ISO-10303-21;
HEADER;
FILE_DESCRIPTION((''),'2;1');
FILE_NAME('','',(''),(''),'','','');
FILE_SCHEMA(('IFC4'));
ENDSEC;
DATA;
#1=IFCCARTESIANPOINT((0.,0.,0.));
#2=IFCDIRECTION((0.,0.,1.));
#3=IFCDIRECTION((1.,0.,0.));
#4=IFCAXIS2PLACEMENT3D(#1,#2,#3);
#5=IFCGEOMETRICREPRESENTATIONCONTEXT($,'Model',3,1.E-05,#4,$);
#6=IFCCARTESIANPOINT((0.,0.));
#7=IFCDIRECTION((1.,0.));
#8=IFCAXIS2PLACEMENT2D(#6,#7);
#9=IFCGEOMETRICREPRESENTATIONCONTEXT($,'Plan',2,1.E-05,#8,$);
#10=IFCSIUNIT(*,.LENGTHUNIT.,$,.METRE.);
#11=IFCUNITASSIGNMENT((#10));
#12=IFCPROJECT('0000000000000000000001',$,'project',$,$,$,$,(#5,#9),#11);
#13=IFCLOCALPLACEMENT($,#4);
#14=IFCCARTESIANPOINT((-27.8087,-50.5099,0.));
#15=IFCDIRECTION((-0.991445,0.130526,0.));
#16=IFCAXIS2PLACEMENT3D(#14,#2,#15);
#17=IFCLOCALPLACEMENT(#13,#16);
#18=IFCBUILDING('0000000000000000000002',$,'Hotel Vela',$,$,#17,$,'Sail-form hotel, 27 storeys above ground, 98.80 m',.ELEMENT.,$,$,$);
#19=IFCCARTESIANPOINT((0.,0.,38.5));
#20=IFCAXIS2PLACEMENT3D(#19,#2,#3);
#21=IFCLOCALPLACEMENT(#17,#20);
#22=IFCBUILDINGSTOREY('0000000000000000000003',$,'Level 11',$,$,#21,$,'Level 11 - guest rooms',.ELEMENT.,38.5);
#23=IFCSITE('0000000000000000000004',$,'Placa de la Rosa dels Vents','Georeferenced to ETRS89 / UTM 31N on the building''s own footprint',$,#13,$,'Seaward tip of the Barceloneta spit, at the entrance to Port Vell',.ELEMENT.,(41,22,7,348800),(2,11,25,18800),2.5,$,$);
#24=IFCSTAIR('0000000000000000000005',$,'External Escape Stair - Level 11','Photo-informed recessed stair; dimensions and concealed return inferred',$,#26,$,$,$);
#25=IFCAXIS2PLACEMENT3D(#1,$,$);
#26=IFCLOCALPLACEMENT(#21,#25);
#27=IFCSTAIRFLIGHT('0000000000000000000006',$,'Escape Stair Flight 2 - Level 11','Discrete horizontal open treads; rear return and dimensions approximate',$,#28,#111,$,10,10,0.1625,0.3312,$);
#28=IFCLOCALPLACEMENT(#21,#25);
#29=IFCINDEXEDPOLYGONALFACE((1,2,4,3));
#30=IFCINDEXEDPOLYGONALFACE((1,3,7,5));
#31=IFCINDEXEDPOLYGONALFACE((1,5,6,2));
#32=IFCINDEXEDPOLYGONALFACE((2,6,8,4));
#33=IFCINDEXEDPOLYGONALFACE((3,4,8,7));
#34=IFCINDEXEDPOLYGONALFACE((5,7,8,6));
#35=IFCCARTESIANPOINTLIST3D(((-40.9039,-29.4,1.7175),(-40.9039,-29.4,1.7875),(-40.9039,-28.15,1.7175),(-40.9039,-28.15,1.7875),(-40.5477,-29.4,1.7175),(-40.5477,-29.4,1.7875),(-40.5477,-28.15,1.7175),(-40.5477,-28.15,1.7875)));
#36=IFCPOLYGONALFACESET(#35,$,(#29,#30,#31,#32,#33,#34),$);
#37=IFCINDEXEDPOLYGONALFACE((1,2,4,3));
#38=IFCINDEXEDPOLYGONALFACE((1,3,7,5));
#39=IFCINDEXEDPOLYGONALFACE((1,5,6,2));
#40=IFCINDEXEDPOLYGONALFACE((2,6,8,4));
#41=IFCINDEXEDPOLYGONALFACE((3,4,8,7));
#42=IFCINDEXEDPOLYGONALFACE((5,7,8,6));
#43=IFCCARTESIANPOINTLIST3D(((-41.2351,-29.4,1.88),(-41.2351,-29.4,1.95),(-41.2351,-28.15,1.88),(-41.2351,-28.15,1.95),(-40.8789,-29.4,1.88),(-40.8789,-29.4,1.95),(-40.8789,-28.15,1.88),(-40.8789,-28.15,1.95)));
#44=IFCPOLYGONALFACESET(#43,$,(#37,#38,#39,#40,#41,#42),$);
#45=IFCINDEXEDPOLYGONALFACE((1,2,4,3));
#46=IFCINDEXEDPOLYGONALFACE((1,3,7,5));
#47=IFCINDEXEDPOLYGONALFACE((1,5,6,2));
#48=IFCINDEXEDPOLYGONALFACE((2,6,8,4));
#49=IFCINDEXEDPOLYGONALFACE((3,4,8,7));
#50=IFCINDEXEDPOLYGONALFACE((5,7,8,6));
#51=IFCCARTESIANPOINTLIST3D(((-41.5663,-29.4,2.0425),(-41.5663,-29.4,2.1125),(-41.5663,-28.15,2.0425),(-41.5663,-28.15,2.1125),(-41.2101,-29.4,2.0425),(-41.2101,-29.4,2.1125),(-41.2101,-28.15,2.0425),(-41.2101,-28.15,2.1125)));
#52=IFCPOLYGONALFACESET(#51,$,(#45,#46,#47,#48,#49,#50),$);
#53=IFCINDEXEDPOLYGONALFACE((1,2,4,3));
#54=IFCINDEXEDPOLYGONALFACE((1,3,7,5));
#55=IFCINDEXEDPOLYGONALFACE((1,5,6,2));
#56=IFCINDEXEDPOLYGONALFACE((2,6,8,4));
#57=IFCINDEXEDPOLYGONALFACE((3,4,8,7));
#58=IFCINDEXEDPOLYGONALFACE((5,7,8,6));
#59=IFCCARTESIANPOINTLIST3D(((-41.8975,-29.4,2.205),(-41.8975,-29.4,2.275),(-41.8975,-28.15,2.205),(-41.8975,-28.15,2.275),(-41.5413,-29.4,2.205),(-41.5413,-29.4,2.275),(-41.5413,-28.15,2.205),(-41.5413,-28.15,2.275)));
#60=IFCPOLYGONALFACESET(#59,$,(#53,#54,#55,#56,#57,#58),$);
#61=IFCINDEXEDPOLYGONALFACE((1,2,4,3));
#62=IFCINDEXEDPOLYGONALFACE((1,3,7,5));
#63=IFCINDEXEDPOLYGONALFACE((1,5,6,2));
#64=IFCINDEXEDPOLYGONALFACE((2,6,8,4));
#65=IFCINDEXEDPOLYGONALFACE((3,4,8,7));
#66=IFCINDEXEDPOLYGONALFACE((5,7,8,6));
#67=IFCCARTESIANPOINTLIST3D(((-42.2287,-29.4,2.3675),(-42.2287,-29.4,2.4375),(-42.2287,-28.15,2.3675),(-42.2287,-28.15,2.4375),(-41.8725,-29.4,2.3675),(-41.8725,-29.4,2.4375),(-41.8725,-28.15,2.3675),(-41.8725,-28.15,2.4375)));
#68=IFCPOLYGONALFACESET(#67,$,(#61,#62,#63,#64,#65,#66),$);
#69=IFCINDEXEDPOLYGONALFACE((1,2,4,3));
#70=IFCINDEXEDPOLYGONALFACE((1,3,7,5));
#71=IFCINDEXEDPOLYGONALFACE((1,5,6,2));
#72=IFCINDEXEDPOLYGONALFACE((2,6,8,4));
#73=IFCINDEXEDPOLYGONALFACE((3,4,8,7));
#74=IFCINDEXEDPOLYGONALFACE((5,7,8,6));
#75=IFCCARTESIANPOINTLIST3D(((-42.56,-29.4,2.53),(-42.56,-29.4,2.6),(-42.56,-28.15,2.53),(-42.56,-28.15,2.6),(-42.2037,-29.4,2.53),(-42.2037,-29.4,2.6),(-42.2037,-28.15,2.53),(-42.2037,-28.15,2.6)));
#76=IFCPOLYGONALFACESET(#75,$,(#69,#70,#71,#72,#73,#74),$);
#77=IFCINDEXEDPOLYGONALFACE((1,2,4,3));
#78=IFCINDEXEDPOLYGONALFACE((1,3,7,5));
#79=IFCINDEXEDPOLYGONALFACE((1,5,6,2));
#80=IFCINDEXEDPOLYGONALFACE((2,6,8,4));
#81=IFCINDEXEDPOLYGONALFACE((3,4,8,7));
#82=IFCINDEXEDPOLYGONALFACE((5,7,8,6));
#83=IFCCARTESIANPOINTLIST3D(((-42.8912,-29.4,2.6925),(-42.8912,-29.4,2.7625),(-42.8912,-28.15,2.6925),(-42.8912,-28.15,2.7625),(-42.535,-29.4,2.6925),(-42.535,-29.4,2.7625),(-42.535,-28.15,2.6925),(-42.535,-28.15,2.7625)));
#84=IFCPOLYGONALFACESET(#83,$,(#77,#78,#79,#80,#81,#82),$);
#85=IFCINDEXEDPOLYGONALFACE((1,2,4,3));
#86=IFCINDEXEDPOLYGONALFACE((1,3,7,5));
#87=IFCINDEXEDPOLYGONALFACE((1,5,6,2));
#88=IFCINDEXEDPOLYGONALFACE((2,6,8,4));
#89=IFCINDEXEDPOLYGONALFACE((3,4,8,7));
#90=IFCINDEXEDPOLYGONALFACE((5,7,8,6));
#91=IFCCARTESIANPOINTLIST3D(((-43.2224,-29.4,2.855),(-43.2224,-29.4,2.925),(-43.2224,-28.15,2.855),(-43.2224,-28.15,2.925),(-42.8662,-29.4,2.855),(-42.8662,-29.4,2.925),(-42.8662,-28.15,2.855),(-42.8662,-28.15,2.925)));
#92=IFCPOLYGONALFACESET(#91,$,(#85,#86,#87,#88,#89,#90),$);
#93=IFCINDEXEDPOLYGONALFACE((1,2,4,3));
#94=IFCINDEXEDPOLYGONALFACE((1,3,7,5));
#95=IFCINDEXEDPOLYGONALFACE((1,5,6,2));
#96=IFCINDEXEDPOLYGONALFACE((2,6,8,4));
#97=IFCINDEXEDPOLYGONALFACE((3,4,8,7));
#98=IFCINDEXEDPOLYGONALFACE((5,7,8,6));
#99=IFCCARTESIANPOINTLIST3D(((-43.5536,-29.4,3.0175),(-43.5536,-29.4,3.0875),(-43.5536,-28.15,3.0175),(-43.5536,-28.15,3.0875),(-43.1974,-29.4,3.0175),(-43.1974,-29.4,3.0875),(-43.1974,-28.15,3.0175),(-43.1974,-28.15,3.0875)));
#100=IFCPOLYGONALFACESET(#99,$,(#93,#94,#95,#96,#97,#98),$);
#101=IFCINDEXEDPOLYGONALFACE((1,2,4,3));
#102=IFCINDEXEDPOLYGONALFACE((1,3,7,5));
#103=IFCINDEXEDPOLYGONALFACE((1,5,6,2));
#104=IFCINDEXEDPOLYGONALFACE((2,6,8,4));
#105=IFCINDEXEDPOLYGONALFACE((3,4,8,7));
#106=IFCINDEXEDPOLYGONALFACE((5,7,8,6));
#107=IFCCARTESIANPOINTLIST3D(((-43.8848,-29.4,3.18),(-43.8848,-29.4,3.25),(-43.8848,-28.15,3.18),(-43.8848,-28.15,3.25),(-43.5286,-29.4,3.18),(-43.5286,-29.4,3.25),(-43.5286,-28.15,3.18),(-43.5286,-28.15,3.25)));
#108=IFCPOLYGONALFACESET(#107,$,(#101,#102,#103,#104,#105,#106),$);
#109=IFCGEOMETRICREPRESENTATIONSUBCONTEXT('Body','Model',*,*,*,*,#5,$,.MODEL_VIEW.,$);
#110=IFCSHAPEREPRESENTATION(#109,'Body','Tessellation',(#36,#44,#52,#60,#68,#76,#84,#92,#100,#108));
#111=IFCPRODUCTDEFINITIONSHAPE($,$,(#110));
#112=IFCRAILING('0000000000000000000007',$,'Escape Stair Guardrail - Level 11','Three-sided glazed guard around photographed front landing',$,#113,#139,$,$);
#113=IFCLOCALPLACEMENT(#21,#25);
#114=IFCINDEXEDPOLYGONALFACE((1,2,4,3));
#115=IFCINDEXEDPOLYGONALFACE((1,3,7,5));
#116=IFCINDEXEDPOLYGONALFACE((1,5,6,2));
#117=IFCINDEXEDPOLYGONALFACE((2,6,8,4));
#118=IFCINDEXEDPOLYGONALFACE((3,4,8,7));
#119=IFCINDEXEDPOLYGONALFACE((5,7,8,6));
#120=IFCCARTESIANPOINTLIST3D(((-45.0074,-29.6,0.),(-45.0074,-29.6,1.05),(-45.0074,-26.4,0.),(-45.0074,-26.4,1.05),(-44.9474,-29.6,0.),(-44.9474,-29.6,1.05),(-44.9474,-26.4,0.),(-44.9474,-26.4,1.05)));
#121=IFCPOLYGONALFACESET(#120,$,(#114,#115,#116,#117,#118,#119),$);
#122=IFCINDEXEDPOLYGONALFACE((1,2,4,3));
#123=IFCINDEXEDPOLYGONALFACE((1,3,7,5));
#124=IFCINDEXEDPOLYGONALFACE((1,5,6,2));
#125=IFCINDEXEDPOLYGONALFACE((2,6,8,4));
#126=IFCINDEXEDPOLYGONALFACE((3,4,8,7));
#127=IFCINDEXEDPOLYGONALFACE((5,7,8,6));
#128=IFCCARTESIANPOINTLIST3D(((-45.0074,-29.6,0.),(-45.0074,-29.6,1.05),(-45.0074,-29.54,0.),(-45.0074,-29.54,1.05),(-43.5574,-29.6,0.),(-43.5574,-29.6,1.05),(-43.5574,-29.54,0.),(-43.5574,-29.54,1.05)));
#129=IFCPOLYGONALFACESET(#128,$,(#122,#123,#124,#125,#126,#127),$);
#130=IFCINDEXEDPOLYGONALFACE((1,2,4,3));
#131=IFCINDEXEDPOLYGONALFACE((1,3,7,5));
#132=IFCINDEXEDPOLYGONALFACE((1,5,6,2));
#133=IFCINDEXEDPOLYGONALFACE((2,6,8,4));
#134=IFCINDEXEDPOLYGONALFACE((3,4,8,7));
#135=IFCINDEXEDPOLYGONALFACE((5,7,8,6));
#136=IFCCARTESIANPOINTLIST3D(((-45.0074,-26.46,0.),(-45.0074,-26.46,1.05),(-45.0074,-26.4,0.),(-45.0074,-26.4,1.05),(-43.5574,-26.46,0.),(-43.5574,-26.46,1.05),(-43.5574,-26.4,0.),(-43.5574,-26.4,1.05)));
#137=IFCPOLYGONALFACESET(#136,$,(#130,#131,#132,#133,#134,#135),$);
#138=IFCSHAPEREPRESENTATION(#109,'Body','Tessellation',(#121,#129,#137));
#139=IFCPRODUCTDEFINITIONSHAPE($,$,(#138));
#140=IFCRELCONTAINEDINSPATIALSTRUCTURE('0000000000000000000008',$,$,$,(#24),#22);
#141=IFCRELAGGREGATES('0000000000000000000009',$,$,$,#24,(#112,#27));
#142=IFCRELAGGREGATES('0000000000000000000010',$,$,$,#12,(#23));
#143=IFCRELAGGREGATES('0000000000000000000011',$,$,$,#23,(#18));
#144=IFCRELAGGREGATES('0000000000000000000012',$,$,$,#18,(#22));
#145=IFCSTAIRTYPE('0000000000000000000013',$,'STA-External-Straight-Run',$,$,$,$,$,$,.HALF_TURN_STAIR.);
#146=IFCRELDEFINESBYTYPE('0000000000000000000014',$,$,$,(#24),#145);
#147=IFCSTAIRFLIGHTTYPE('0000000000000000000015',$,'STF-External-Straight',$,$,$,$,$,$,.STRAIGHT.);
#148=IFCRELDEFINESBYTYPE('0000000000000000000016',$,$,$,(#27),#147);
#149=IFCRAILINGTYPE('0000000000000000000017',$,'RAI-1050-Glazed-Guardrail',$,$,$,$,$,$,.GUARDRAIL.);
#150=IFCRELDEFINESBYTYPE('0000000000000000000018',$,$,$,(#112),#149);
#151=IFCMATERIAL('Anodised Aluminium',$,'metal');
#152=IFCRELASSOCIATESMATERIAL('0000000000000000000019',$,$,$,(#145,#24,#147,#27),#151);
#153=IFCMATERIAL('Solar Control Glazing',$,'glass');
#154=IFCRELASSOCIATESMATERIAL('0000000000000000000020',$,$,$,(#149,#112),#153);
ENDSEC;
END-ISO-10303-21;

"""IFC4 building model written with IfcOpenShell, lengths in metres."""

from ifc_helpers import new_model, si_unit, frame, origin_with_axes, origin_2d_with_axis, place, context, subcontext, project, spatial, line, indexed_curve, outline, extrude, material, type_object, element, aggregate, save


model = new_model("IFC4")

# Units and contexts
model_context = context("Model", 3, precision=1e-05, world=origin_with_axes())
plan_context = context("Plan", 2, precision=1e-05, world=origin_2d_with_axis())
body_context = subcontext(model_context, "Body", "Model", "MODEL_VIEW")
ifc_project = project(units=[si_unit("LENGTHUNIT", "METRE")], contexts=[model_context, plan_context])

# Site, building, storey
site_placement = place(None, origin_with_axes())
site = spatial("IfcSite", under=ifc_project, at=site_placement, Name="Placa de la Rosa dels Vents", Description="Georeferenced to ETRS89 / UTM 31N on the building's own footprint", LongName="Seaward tip of the Barceloneta spit, at the entrance to Port Vell", CompositionType="ELEMENT", RefLatitude=(41, 22, 7, 348800), RefLongitude=(2, 11, 25, 18800), RefElevation=2.5)
building_placement = place(site_placement, frame((-27.8087, -50.5099, 0.0), z_axis=(0.0, 0.0, 1.0), x_axis=(-0.991445, 0.130526, 0.0)))
building = spatial("IfcBuilding", under=site, at=building_placement, Name="Hotel Vela", LongName="Sail-form hotel, 27 storeys above ground, 98.80 m", CompositionType="ELEMENT")
storey_placement = place(building_placement, frame((0.0, 0.0, 38.5), z_axis=(0.0, 0.0, 1.0), x_axis=(1.0, 0.0, 0.0)))
storey = spatial("IfcBuildingStorey", under=building, at=storey_placement, Name="Level 11", LongName="Level 11 - guest rooms", CompositionType="ELEMENT", Elevation=38.5)

# Stair
ifc_material_1 = material(Name="Anodised Aluminium", Category="metal")
stair_type = type_object("IfcStairType", Name="STA-External-Straight-Run", PredefinedType="HALF_TURN_STAIR", material=ifc_material_1)
stair_placement = place(storey_placement, frame((0.0, 0.0, -38.5), z_axis=(0.0, 0.0, 1.0), x_axis=(1.0, 0.0, 0.0)))
stair = element("IfcStair", 1, at=stair_placement, inside=storey, type_object=stair_type, material=ifc_material_1, Name="External Escape Stair - Level 11", Description="Photo-informed recessed stair; dimensions and concealed return inferred")

# Stair flight
stair_flight_type = type_object("IfcStairFlightType", Name="STF-External-Straight", PredefinedType="STRAIGHT", material=ifc_material_1)
stair_flight_1_placement = place(stair_placement, origin_with_axes())
stair_flight_1 = element("IfcStairFlight", 2, at=stair_flight_1_placement, type_object=stair_flight_type, material=ifc_material_1, Name="Escape Stair Flight 2 - Level 11", Description="Discrete horizontal open treads; rear return and dimensions approximate", NumberOfRisers=10, NumberOfTreads=10, RiserHeight=0.1625, TreadLength=0.3312, context=body_context, shape_type="SweptSolid", body=[
    extrude(outline(indexed_curve([(0.0, 0.0), (0.3562, 0.0), (0.3562, 1.25), (0.0, 1.25)], segments=[line(1, 2, 3, 4, 1)])), frame((-40.9039, -29.4, 40.2175), z_axis=(0.0, 0.0, 1.0), x_axis=(1.0, 0.0, 0.0)), (0.0, 0.0, 1.0), 0.07),
    extrude(outline(indexed_curve([(0.0, 0.0), (0.3562, 0.0), (0.3562, 1.25), (0.0, 1.25)], segments=[line(1, 2, 3, 4, 1)])), frame((-41.2351, -29.4, 40.38), z_axis=(0.0, 0.0, 1.0), x_axis=(1.0, 0.0, 0.0)), (0.0, 0.0, 1.0), 0.07),
    extrude(outline(indexed_curve([(0.0, 0.0), (0.3562, 0.0), (0.3562, 1.25), (0.0, 1.25)], segments=[line(1, 2, 3, 4, 1)])), frame((-41.5663, -29.4, 40.5425), z_axis=(0.0, 0.0, 1.0), x_axis=(1.0, 0.0, 0.0)), (0.0, 0.0, 1.0), 0.07),
    extrude(outline(indexed_curve([(0.0, 0.0), (0.3562, 0.0), (0.3562, 1.25), (0.0, 1.25)], segments=[line(1, 2, 3, 4, 1)])), frame((-41.8975, -29.4, 40.705), z_axis=(0.0, 0.0, 1.0), x_axis=(1.0, 0.0, 0.0)), (0.0, 0.0, 1.0), 0.07),
    extrude(outline(indexed_curve([(0.0, 0.0), (0.3562, 0.0), (0.3562, 1.25), (0.0, 1.25)], segments=[line(1, 2, 3, 4, 1)])), frame((-42.2287, -29.4, 40.8675), z_axis=(0.0, 0.0, 1.0), x_axis=(1.0, 0.0, 0.0)), (0.0, 0.0, 1.0), 0.07),
    extrude(outline(indexed_curve([(0.0, 0.0), (0.3562, 0.0), (0.3562, 1.25), (0.0, 1.25)], segments=[line(1, 2, 3, 4, 1)])), frame((-42.56, -29.4, 41.03), z_axis=(0.0, 0.0, 1.0), x_axis=(1.0, 0.0, 0.0)), (0.0, 0.0, 1.0), 0.07),
    extrude(outline(indexed_curve([(0.0, 0.0), (0.3562, 0.0), (0.3562, 1.25), (0.0, 1.25)], segments=[line(1, 2, 3, 4, 1)])), frame((-42.8912, -29.4, 41.1925), z_axis=(0.0, 0.0, 1.0), x_axis=(1.0, 0.0, 0.0)), (0.0, 0.0, 1.0), 0.07),
    extrude(outline(indexed_curve([(0.0, 0.0), (0.3562, 0.0), (0.3562, 1.25), (0.0, 1.25)], segments=[line(1, 2, 3, 4, 1)])), frame((-43.2224, -29.4, 41.355), z_axis=(0.0, 0.0, 1.0), x_axis=(1.0, 0.0, 0.0)), (0.0, 0.0, 1.0), 0.07),
    extrude(outline(indexed_curve([(0.0, 0.0), (0.3562, 0.0), (0.3562, 1.25), (0.0, 1.25)], segments=[line(1, 2, 3, 4, 1)])), frame((-43.5536, -29.4, 41.5175), z_axis=(0.0, 0.0, 1.0), x_axis=(1.0, 0.0, 0.0)), (0.0, 0.0, 1.0), 0.07),
    extrude(outline(indexed_curve([(0.0, 0.0), (0.3562, 0.0), (0.3562, 1.25), (0.0, 1.25)], segments=[line(1, 2, 3, 4, 1)])), frame((-43.8848, -29.4, 41.68), z_axis=(0.0, 0.0, 1.0), x_axis=(1.0, 0.0, 0.0)), (0.0, 0.0, 1.0), 0.07),
])

# Railing
ifc_material_2 = material(Name="Solar Control Glazing", Category="glass")
railing_type = type_object("IfcRailingType", Name="RAI-1050-Glazed-Guardrail", PredefinedType="GUARDRAIL", material=ifc_material_2)
railing_placement = place(stair_placement, origin_with_axes())
railing = element("IfcRailing", 3, at=railing_placement, type_object=railing_type, material=ifc_material_2, Name="Escape Stair Guardrail - Level 11", Description="Three-sided glazed guard around photographed front landing", context=body_context, shape_type="SweptSolid", body=[
    extrude(outline(indexed_curve([(0.0, 0.0), (0.06, 0.0), (0.06, 3.2), (0.0, 3.2)], segments=[line(1, 2, 3, 4, 1)])), frame((-45.0074, -29.6, 38.5), z_axis=(0.0, 0.0, 1.0), x_axis=(1.0, 0.0, 0.0)), (0.0, 0.0, 1.0), 1.05),
    extrude(outline(indexed_curve([(0.0, 0.0), (1.45, 0.0), (1.45, 0.06), (0.0, 0.06)], segments=[line(1, 2, 3, 4, 1)])), frame((-45.0074, -29.6, 38.5), z_axis=(0.0, 0.0, 1.0), x_axis=(1.0, 0.0, 0.0)), (0.0, 0.0, 1.0), 1.05),
    extrude(outline(indexed_curve([(0.0, 0.0), (1.45, 0.0), (1.45, 0.06), (0.0, 0.06)], segments=[line(1, 2, 3, 4, 1)])), frame((-45.0074, -26.46, 38.5), z_axis=(0.0, 0.0, 1.0), x_axis=(1.0, 0.0, 0.0)), (0.0, 0.0, 1.0), 1.05),
])
aggregate(stair, [railing, stair_flight_1])

save(model, "model.ifc")
